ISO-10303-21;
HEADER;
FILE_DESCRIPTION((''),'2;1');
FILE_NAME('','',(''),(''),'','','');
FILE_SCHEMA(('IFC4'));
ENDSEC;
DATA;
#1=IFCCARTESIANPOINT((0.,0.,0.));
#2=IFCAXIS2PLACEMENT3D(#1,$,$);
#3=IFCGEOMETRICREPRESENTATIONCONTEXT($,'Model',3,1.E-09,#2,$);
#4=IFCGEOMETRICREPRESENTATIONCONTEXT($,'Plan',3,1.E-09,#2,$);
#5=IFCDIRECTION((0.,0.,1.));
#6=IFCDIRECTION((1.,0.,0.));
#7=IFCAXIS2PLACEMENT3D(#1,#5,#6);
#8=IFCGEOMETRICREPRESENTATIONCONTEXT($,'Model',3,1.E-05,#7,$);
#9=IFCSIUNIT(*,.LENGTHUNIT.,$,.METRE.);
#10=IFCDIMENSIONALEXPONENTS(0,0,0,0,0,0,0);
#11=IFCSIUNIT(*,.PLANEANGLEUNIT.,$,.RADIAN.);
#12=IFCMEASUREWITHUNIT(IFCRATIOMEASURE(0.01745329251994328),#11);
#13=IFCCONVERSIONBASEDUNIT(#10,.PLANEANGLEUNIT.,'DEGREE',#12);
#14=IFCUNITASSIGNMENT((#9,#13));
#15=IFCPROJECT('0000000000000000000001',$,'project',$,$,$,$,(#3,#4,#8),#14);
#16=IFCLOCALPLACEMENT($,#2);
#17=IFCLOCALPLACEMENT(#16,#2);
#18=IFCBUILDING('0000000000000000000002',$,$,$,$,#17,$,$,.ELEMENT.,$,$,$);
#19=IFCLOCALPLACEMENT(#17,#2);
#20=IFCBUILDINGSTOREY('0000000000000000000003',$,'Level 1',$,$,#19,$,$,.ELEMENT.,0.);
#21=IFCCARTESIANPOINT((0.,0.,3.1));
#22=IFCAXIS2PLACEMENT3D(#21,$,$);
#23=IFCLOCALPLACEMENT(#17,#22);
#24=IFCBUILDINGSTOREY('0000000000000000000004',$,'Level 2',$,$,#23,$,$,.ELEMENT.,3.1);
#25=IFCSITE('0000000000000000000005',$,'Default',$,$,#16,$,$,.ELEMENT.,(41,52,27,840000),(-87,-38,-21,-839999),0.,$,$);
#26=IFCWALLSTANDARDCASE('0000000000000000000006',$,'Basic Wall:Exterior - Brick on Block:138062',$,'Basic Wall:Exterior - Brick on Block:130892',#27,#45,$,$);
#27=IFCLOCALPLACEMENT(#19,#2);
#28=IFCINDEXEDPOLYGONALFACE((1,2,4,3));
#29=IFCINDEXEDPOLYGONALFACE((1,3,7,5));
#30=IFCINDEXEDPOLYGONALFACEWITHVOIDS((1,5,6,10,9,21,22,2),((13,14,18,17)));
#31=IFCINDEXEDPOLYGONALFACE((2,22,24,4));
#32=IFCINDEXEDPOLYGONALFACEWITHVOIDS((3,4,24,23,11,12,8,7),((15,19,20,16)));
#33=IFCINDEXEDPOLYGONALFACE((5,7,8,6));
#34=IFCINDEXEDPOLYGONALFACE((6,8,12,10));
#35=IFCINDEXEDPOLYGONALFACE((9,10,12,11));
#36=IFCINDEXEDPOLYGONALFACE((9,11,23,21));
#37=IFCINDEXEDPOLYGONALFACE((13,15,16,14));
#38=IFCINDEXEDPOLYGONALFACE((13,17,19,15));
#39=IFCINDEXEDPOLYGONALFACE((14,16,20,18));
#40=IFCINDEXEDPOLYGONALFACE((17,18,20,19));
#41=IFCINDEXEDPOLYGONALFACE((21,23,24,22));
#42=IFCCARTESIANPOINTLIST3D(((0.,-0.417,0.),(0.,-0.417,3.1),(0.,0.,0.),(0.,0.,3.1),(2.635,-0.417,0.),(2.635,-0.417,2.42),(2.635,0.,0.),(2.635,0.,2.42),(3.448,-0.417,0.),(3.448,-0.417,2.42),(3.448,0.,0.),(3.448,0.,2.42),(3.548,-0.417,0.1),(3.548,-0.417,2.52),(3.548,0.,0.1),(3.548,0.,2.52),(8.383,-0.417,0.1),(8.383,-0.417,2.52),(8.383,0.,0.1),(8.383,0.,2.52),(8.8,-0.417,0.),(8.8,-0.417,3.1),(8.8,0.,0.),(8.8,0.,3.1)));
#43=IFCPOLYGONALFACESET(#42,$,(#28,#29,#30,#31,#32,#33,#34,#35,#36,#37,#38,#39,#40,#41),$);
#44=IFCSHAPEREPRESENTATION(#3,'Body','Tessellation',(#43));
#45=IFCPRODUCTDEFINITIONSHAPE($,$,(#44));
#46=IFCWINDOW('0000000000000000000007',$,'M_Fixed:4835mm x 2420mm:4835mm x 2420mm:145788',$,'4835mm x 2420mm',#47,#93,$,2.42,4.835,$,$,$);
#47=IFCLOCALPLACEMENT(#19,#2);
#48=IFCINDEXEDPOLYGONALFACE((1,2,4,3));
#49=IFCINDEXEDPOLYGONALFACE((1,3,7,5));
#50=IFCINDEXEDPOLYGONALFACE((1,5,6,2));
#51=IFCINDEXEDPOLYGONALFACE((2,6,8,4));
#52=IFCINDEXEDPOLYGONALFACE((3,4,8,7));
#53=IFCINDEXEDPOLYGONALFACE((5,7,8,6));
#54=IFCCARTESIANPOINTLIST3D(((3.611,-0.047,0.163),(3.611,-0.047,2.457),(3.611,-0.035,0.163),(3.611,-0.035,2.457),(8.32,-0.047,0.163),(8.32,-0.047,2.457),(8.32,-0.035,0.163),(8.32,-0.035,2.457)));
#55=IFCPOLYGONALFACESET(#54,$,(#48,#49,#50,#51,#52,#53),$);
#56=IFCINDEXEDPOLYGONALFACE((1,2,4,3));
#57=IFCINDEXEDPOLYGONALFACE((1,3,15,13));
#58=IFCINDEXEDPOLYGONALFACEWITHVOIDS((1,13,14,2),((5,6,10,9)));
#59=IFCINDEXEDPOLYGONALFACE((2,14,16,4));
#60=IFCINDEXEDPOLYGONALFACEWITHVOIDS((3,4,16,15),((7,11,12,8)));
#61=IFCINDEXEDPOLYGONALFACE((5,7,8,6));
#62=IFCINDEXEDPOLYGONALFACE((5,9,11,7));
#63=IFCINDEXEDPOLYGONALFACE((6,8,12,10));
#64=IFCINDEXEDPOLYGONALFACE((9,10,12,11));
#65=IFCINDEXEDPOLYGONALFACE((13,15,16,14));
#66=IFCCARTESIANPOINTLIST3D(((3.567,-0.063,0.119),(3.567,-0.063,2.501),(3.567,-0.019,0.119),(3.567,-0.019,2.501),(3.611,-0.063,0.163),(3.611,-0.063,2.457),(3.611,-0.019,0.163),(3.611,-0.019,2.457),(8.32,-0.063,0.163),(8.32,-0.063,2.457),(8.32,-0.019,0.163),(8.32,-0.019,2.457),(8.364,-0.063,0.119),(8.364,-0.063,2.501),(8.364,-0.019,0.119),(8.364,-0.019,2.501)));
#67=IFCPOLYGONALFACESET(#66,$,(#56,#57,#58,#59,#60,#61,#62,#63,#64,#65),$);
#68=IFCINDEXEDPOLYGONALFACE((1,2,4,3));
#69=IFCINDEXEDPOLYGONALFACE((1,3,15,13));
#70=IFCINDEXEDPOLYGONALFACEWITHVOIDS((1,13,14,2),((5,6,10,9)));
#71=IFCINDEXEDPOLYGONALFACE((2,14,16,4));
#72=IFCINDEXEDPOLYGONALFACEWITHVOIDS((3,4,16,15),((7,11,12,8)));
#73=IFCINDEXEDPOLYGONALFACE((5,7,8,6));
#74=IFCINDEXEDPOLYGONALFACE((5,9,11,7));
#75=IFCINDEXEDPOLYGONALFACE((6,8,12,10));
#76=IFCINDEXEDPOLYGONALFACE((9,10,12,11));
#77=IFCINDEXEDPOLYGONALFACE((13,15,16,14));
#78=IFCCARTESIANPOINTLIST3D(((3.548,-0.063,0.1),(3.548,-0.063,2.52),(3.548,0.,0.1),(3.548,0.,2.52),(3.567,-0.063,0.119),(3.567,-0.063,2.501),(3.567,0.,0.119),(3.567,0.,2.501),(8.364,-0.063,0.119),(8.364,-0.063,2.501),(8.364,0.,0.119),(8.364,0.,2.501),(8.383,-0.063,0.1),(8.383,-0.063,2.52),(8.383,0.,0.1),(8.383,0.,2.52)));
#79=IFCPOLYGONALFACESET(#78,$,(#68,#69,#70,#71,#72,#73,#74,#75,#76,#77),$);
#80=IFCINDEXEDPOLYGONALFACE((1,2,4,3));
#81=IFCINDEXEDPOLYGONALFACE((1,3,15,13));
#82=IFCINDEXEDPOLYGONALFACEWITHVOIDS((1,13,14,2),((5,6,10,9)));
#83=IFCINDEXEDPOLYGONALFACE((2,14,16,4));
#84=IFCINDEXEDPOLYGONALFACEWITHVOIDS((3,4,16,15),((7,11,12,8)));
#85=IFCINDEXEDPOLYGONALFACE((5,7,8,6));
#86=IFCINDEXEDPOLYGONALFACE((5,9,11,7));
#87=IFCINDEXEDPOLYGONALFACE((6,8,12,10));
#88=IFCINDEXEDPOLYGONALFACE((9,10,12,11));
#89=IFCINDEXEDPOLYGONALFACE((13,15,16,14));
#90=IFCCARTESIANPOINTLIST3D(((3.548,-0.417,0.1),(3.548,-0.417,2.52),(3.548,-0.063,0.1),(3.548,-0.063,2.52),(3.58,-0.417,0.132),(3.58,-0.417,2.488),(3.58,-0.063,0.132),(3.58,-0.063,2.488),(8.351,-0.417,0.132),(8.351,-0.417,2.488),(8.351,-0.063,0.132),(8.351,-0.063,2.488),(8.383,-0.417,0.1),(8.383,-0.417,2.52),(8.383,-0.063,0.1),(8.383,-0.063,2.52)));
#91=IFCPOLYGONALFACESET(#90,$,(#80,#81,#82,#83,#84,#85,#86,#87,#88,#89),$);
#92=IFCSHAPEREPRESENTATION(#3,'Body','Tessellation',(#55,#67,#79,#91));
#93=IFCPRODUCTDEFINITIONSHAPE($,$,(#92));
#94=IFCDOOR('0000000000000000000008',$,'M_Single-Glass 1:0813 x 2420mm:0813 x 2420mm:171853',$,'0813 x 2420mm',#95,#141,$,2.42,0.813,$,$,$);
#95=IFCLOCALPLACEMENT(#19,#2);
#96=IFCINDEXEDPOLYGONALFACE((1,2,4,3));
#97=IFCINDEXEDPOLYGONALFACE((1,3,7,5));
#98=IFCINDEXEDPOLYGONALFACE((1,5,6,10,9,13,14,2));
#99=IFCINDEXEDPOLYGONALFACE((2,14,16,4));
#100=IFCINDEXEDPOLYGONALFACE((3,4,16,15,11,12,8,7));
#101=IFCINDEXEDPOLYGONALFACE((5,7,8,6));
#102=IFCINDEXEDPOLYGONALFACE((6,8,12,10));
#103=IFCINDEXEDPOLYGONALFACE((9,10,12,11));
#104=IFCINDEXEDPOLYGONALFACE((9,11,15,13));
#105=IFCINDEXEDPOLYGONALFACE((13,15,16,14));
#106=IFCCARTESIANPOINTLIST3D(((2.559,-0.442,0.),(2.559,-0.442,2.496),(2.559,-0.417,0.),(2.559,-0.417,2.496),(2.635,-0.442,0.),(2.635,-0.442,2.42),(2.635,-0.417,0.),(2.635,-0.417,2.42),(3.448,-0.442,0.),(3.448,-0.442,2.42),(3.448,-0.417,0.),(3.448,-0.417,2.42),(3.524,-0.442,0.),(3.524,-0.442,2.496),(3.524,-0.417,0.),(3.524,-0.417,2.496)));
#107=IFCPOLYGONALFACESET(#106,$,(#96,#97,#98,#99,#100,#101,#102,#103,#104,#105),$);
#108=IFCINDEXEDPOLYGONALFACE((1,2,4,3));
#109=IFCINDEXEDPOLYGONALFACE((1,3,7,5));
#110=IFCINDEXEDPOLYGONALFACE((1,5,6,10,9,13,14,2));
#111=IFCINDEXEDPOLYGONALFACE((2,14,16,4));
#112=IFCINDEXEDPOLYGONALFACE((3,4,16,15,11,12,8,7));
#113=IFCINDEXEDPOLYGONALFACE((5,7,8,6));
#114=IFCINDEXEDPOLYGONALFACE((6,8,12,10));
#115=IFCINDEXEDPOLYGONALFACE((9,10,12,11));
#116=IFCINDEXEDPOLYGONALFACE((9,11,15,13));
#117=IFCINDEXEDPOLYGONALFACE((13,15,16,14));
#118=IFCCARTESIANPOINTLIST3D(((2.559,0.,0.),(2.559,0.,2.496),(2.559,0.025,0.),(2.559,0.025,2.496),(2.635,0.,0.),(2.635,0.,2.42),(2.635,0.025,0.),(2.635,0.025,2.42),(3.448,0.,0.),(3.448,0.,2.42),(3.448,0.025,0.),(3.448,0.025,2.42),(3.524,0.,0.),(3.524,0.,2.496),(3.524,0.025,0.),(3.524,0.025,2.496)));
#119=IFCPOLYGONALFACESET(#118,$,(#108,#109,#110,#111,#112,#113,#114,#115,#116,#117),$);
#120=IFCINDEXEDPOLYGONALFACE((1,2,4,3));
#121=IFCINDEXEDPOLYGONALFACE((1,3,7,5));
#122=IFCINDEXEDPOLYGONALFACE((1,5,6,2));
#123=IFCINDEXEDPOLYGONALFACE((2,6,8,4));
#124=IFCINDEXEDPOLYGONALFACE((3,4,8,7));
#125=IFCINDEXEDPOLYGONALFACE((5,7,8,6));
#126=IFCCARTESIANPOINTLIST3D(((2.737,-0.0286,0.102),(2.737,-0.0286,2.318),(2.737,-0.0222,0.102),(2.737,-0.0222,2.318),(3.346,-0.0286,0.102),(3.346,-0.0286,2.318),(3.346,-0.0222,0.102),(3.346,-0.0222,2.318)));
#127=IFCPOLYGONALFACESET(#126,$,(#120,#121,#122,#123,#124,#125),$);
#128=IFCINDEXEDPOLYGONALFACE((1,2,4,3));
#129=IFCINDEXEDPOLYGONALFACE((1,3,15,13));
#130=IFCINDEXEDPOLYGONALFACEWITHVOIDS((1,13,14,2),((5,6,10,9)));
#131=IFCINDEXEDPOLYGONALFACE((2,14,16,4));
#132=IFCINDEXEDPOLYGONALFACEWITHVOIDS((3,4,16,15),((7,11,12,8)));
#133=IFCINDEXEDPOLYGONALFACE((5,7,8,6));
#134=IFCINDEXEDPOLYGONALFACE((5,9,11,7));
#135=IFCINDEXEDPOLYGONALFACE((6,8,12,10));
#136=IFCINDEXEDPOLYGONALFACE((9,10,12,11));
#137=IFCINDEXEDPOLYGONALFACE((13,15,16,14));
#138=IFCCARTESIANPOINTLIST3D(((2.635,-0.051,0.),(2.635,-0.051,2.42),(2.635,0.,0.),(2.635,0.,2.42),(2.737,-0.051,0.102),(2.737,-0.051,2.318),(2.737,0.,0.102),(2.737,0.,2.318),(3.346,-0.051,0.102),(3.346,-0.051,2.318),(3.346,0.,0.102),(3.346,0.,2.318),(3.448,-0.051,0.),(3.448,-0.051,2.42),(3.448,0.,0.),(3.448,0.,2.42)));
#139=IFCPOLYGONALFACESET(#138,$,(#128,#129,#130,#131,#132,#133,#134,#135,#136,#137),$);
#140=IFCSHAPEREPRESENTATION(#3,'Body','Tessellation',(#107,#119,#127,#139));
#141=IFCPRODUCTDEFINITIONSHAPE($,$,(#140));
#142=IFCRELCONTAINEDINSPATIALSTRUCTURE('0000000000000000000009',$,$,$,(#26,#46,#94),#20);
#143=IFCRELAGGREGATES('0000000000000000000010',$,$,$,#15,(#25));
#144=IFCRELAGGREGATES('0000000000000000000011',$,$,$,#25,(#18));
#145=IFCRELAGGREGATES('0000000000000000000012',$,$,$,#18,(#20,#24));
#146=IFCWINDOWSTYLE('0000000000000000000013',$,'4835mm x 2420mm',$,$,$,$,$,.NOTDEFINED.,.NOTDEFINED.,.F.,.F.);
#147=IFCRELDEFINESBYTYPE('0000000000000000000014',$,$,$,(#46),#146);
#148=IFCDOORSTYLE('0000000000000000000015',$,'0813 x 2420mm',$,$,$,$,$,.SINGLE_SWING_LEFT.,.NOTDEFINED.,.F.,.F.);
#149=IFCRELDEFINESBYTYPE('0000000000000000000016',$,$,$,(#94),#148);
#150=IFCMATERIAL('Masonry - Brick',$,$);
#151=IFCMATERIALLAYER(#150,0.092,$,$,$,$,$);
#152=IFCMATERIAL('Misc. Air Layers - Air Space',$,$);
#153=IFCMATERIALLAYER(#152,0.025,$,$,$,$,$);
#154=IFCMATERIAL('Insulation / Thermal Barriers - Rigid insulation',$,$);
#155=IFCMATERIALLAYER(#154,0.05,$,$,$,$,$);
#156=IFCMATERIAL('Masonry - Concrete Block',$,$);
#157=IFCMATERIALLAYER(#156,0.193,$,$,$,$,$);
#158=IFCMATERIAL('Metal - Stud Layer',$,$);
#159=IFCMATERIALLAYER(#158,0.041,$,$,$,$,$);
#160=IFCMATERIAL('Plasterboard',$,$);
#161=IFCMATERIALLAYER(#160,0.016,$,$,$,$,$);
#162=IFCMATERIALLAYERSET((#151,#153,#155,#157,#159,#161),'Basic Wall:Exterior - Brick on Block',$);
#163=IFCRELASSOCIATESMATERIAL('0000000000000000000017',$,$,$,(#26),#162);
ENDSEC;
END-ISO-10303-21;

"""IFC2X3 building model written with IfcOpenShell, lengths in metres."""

from ifc_helpers import new_model, entity, si_unit, converted_unit, frame, frame_2d, origin, origin_with_axes, origin_2d_with_axis, place, context, project, spatial, polyline, rectangle, outline, extrude, source, transform, mapped, material, layer, layer_set, layer_usage, type_object, type_shapes, element, fill, save


model = new_model("IFC2X3")

# Units and contexts
model_context_1 = context("Model", 3, precision=1e-09, world=origin())
plan_context = context("Plan", 3, precision=1e-09, world=origin())
model_context_2 = context("Model", 3, precision=1e-05, world=origin_with_axes())
ifc_project = project(units=[si_unit("LENGTHUNIT", "METRE"), converted_unit("PLANEANGLEUNIT", "DEGREE", entity("IfcRatioMeasure", 0.01745329251994328), si_unit("PLANEANGLEUNIT", "RADIAN"), dimensions=[0, 0, 0, 0, 0, 0, 0])], contexts=[model_context_1, plan_context, model_context_2])

# Site, building, storey
site_placement = place(None, origin())
site = spatial("IfcSite", under=ifc_project, at=site_placement, Name="Default", CompositionType="ELEMENT", RefLatitude=(41, 52, 27, 840000), RefLongitude=(-87, -38, -21, -839999), RefElevation=0.0)
building_placement = place(site_placement, origin())
building = spatial("IfcBuilding", under=site, at=building_placement, CompositionType="ELEMENT")
storey_1_placement = place(building_placement, origin())
storey_1 = spatial("IfcBuildingStorey", under=building, at=storey_1_placement, Name="Level 1", CompositionType="ELEMENT", Elevation=0.0)

# Wall, openings, window, door
ifc_material_1 = material(Name="Masonry - Brick")
ifc_layer_1 = layer(ifc_material_1, 0.092)
ifc_material_2 = material(Name="Misc. Air Layers - Air Space")
ifc_layer_2 = layer(ifc_material_2, 0.025)
ifc_material_3 = material(Name="Insulation / Thermal Barriers - Rigid insulation")
ifc_layer_3 = layer(ifc_material_3, 0.05)
ifc_material_4 = material(Name="Masonry - Concrete Block")
ifc_layer_4 = layer(ifc_material_4, 0.193)
ifc_material_5 = material(Name="Metal - Stud Layer")
ifc_layer_5 = layer(ifc_material_5, 0.041)
ifc_material_6 = material(Name="Plasterboard")
ifc_layer_6 = layer(ifc_material_6, 0.016)
ifc_layer_set_1 = layer_set([ifc_layer_1, ifc_layer_2, ifc_layer_3, ifc_layer_4, ifc_layer_5, ifc_layer_6], Name="Basic Wall:Exterior - Brick on Block")
ifc_layer_usage_1 = layer_usage(ifc_layer_set_1, "AXIS2", "NEGATIVE", 0.2085)
wall_1_placement = place(storey_1_placement, frame((0.0, -0.2085, 0.0)))
wall_1 = element("IfcWallStandardCase", 1, at=wall_1_placement, inside=storey_1, material=ifc_layer_usage_1, Name="Basic Wall:Exterior - Brick on Block:138062", ObjectType="Basic Wall:Exterior - Brick on Block:130892", context=model_context_1, shape_type="SweptSolid", body=[
    extrude(rectangle(XDim=8.8, YDim=0.417, at=frame_2d((4.4, 0.0), x_axis=(-1.0, 0.0))), origin(), (0.0, 0.0, 1.0), 3.1),
])
opening_1_placement = place(wall_1_placement, frame((3.548, -0.2085, 0.1)))
opening_1 = element("IfcOpeningElement", 2, at=opening_1_placement, cuts=wall_1, ObjectType="Opening", context=model_context_1, shape_type="SweptSolid", body=[
    extrude(rectangle(XDim=2.42, YDim=4.835, at=frame_2d((1.21, 2.4175), x_axis=(1.0, 0.0))), frame((0.0, 0.0, 0.0), z_axis=(0.0, 1.0, 0.0), x_axis=(0.0, 0.0, 1.0)), (0.0, 0.0, 1.0), 0.417),
])
opening_2_placement = place(wall_1_placement, frame((2.635, -0.2085, 0.0)))
opening_2 = element("IfcOpeningElement", 3, at=opening_2_placement, cuts=wall_1, ObjectType="Opening", context=model_context_1, shape_type="SweptSolid", body=[
    extrude(rectangle(XDim=0.813, YDim=2.42, at=frame_2d((1.21, 0.4065), x_axis=(0.0, -1.0))), frame((0.0, 0.0, 0.0), z_axis=(0.0, 1.0, 0.0), x_axis=(0.0, 0.0, 1.0)), (0.0, 0.0, 1.0), 0.417),
])
window_style_1 = type_object("IfcWindowStyle", Name="4835mm x 2420mm", ConstructionType="NOTDEFINED", OperationType="NOTDEFINED", ParameterTakesPrecedence=False, Sizeable=False)
shared_shape_1 = source(origin(), model_context_1, "Body", "SweptSolid", [
    extrude(rectangle(XDim=0.012, YDim=4.709, at=origin_2d_with_axis()), frame((2.4175, 0.376, 0.063), z_axis=(0.0, 0.0, 1.0), x_axis=(0.0, -1.0, 0.0)), (0.0, 0.0, 1.0), 2.294),
    extrude(outline(polyline([(-2.3985, -1.191), (2.3985, -1.191), (2.3985, 1.191), (-2.3985, 1.191), (-2.3985, -1.191)]), holes=[polyline([(-2.3545, -1.147), (-2.3545, 1.147), (2.3545, 1.147), (2.3545, -1.147), (-2.3545, -1.147)])]), frame((2.4175, 0.354, 1.21), z_axis=(0.0, 1.0, 0.0), x_axis=(1.0, 0.0, 0.0)), (0.0, 0.0, 1.0), 0.044),
    extrude(outline(polyline([(-2.4175, -1.21), (2.4175, -1.21), (2.4175, 1.21), (-2.4175, 1.21), (-2.4175, -1.21)]), holes=[polyline([(-2.3985, -1.191), (-2.3985, 1.191), (2.3985, 1.191), (2.3985, -1.191), (-2.3985, -1.191)])]), frame((2.4175, 0.354, 1.21), z_axis=(0.0, 1.0, 0.0), x_axis=(1.0, 0.0, 0.0)), (0.0, 0.0, 1.0), 0.063),
    extrude(outline(polyline([(-2.4175, -1.21), (2.4175, -1.21), (2.4175, 1.21), (-2.4175, 1.21), (-2.4175, -1.21)]), holes=[polyline([(-2.3855, -1.178), (-2.3855, 1.178), (2.3855, 1.178), (2.3855, -1.178), (-2.3855, -1.178)])]), frame((2.4175, 0.0, 1.21), z_axis=(0.0, 1.0, 0.0), x_axis=(1.0, 0.0, 0.0)), (0.0, 0.0, 1.0), 0.354),
])
type_shapes(window_style_1, [shared_shape_1])
window_1_placement = place(opening_1_placement, origin())
window_1 = element("IfcWindow", 4, at=window_1_placement, inside=storey_1, type_object=window_style_1, Name="M_Fixed:4835mm x 2420mm:4835mm x 2420mm:145788", ObjectType="4835mm x 2420mm", OverallHeight=2.42, OverallWidth=4.835, context=model_context_1, shape_type="MappedRepresentation", body=[
    mapped(shared_shape_1, transform((0.0, 0.0, 0.0), scale=1.0)),
])
fill(opening_1, window_1)
door_style_1 = type_object("IfcDoorStyle", Name="0813 x 2420mm", ConstructionType="NOTDEFINED", OperationType="SINGLE_SWING_LEFT", ParameterTakesPrecedence=False, Sizeable=False)
shared_shape_2 = source(origin(), model_context_1, "Body", "SweptSolid", [
    extrude(outline(polyline([(-0.4065, -1.191), (-0.4065, 1.229), (-0.4825, 1.229), (-0.4825, -1.267), (0.4825, -1.267), (0.4825, 1.229), (0.4065, 1.229), (0.4065, -1.191), (-0.4065, -1.191)])), frame((0.4065, 0.0, 1.229), z_axis=(0.0, 1.0, 0.0), x_axis=(1.0, 0.0, 0.0)), (0.0, 0.0, -1.0), 0.025),
    extrude(outline(polyline([(-0.4065, -1.191), (-0.4065, 1.229), (-0.4825, 1.229), (-0.4825, -1.267), (0.4825, -1.267), (0.4825, 1.229), (0.4065, 1.229), (0.4065, -1.191), (-0.4065, -1.191)])), frame((0.4065, 0.442, 1.229), z_axis=(0.0, 1.0, 0.0), x_axis=(1.0, 0.0, 0.0)), (0.0, 0.0, -1.0), 0.025),
    extrude(rectangle(XDim=0.609, YDim=0.0064, at=origin_2d_with_axis()), frame((0.4065, 0.3916, 0.102)), (0.0, 0.0, 1.0), 2.216),
    extrude(outline(polyline([(-1.21, -0.4065), (1.21, -0.4065), (1.21, 0.4065), (-1.21, 0.4065), (-1.21, -0.4065)]), holes=[polyline([(-1.108, 0.3045), (1.108, 0.3045), (1.108, -0.3045), (-1.108, -0.3045), (-1.108, 0.3045)])]), frame((0.4065, 0.417, 1.21), z_axis=(0.0, -1.0, 0.0), x_axis=(0.0, 0.0, -1.0)), (0.0, 0.0, 1.0), 0.051),
])
type_shapes(door_style_1, [shared_shape_2])
door_1_placement = place(opening_2_placement, origin())
door_1 = element("IfcDoor", 5, at=door_1_placement, inside=storey_1, type_object=door_style_1, Name="M_Single-Glass 1:0813 x 2420mm:0813 x 2420mm:171853", ObjectType="0813 x 2420mm", OverallHeight=2.42, OverallWidth=0.813, context=model_context_1, shape_type="MappedRepresentation", body=[
    mapped(shared_shape_2, transform((0.0, 0.0, 0.0), scale=1.0)),
])
fill(opening_2, door_1)

# Shared definitions
storey_2_placement = place(building_placement, frame((0.0, 0.0, 3.1)))
storey_2 = spatial("IfcBuildingStorey", under=building, at=storey_2_placement, Name="Level 2", CompositionType="ELEMENT", Elevation=3.1)

save(model, "model.ifc")
